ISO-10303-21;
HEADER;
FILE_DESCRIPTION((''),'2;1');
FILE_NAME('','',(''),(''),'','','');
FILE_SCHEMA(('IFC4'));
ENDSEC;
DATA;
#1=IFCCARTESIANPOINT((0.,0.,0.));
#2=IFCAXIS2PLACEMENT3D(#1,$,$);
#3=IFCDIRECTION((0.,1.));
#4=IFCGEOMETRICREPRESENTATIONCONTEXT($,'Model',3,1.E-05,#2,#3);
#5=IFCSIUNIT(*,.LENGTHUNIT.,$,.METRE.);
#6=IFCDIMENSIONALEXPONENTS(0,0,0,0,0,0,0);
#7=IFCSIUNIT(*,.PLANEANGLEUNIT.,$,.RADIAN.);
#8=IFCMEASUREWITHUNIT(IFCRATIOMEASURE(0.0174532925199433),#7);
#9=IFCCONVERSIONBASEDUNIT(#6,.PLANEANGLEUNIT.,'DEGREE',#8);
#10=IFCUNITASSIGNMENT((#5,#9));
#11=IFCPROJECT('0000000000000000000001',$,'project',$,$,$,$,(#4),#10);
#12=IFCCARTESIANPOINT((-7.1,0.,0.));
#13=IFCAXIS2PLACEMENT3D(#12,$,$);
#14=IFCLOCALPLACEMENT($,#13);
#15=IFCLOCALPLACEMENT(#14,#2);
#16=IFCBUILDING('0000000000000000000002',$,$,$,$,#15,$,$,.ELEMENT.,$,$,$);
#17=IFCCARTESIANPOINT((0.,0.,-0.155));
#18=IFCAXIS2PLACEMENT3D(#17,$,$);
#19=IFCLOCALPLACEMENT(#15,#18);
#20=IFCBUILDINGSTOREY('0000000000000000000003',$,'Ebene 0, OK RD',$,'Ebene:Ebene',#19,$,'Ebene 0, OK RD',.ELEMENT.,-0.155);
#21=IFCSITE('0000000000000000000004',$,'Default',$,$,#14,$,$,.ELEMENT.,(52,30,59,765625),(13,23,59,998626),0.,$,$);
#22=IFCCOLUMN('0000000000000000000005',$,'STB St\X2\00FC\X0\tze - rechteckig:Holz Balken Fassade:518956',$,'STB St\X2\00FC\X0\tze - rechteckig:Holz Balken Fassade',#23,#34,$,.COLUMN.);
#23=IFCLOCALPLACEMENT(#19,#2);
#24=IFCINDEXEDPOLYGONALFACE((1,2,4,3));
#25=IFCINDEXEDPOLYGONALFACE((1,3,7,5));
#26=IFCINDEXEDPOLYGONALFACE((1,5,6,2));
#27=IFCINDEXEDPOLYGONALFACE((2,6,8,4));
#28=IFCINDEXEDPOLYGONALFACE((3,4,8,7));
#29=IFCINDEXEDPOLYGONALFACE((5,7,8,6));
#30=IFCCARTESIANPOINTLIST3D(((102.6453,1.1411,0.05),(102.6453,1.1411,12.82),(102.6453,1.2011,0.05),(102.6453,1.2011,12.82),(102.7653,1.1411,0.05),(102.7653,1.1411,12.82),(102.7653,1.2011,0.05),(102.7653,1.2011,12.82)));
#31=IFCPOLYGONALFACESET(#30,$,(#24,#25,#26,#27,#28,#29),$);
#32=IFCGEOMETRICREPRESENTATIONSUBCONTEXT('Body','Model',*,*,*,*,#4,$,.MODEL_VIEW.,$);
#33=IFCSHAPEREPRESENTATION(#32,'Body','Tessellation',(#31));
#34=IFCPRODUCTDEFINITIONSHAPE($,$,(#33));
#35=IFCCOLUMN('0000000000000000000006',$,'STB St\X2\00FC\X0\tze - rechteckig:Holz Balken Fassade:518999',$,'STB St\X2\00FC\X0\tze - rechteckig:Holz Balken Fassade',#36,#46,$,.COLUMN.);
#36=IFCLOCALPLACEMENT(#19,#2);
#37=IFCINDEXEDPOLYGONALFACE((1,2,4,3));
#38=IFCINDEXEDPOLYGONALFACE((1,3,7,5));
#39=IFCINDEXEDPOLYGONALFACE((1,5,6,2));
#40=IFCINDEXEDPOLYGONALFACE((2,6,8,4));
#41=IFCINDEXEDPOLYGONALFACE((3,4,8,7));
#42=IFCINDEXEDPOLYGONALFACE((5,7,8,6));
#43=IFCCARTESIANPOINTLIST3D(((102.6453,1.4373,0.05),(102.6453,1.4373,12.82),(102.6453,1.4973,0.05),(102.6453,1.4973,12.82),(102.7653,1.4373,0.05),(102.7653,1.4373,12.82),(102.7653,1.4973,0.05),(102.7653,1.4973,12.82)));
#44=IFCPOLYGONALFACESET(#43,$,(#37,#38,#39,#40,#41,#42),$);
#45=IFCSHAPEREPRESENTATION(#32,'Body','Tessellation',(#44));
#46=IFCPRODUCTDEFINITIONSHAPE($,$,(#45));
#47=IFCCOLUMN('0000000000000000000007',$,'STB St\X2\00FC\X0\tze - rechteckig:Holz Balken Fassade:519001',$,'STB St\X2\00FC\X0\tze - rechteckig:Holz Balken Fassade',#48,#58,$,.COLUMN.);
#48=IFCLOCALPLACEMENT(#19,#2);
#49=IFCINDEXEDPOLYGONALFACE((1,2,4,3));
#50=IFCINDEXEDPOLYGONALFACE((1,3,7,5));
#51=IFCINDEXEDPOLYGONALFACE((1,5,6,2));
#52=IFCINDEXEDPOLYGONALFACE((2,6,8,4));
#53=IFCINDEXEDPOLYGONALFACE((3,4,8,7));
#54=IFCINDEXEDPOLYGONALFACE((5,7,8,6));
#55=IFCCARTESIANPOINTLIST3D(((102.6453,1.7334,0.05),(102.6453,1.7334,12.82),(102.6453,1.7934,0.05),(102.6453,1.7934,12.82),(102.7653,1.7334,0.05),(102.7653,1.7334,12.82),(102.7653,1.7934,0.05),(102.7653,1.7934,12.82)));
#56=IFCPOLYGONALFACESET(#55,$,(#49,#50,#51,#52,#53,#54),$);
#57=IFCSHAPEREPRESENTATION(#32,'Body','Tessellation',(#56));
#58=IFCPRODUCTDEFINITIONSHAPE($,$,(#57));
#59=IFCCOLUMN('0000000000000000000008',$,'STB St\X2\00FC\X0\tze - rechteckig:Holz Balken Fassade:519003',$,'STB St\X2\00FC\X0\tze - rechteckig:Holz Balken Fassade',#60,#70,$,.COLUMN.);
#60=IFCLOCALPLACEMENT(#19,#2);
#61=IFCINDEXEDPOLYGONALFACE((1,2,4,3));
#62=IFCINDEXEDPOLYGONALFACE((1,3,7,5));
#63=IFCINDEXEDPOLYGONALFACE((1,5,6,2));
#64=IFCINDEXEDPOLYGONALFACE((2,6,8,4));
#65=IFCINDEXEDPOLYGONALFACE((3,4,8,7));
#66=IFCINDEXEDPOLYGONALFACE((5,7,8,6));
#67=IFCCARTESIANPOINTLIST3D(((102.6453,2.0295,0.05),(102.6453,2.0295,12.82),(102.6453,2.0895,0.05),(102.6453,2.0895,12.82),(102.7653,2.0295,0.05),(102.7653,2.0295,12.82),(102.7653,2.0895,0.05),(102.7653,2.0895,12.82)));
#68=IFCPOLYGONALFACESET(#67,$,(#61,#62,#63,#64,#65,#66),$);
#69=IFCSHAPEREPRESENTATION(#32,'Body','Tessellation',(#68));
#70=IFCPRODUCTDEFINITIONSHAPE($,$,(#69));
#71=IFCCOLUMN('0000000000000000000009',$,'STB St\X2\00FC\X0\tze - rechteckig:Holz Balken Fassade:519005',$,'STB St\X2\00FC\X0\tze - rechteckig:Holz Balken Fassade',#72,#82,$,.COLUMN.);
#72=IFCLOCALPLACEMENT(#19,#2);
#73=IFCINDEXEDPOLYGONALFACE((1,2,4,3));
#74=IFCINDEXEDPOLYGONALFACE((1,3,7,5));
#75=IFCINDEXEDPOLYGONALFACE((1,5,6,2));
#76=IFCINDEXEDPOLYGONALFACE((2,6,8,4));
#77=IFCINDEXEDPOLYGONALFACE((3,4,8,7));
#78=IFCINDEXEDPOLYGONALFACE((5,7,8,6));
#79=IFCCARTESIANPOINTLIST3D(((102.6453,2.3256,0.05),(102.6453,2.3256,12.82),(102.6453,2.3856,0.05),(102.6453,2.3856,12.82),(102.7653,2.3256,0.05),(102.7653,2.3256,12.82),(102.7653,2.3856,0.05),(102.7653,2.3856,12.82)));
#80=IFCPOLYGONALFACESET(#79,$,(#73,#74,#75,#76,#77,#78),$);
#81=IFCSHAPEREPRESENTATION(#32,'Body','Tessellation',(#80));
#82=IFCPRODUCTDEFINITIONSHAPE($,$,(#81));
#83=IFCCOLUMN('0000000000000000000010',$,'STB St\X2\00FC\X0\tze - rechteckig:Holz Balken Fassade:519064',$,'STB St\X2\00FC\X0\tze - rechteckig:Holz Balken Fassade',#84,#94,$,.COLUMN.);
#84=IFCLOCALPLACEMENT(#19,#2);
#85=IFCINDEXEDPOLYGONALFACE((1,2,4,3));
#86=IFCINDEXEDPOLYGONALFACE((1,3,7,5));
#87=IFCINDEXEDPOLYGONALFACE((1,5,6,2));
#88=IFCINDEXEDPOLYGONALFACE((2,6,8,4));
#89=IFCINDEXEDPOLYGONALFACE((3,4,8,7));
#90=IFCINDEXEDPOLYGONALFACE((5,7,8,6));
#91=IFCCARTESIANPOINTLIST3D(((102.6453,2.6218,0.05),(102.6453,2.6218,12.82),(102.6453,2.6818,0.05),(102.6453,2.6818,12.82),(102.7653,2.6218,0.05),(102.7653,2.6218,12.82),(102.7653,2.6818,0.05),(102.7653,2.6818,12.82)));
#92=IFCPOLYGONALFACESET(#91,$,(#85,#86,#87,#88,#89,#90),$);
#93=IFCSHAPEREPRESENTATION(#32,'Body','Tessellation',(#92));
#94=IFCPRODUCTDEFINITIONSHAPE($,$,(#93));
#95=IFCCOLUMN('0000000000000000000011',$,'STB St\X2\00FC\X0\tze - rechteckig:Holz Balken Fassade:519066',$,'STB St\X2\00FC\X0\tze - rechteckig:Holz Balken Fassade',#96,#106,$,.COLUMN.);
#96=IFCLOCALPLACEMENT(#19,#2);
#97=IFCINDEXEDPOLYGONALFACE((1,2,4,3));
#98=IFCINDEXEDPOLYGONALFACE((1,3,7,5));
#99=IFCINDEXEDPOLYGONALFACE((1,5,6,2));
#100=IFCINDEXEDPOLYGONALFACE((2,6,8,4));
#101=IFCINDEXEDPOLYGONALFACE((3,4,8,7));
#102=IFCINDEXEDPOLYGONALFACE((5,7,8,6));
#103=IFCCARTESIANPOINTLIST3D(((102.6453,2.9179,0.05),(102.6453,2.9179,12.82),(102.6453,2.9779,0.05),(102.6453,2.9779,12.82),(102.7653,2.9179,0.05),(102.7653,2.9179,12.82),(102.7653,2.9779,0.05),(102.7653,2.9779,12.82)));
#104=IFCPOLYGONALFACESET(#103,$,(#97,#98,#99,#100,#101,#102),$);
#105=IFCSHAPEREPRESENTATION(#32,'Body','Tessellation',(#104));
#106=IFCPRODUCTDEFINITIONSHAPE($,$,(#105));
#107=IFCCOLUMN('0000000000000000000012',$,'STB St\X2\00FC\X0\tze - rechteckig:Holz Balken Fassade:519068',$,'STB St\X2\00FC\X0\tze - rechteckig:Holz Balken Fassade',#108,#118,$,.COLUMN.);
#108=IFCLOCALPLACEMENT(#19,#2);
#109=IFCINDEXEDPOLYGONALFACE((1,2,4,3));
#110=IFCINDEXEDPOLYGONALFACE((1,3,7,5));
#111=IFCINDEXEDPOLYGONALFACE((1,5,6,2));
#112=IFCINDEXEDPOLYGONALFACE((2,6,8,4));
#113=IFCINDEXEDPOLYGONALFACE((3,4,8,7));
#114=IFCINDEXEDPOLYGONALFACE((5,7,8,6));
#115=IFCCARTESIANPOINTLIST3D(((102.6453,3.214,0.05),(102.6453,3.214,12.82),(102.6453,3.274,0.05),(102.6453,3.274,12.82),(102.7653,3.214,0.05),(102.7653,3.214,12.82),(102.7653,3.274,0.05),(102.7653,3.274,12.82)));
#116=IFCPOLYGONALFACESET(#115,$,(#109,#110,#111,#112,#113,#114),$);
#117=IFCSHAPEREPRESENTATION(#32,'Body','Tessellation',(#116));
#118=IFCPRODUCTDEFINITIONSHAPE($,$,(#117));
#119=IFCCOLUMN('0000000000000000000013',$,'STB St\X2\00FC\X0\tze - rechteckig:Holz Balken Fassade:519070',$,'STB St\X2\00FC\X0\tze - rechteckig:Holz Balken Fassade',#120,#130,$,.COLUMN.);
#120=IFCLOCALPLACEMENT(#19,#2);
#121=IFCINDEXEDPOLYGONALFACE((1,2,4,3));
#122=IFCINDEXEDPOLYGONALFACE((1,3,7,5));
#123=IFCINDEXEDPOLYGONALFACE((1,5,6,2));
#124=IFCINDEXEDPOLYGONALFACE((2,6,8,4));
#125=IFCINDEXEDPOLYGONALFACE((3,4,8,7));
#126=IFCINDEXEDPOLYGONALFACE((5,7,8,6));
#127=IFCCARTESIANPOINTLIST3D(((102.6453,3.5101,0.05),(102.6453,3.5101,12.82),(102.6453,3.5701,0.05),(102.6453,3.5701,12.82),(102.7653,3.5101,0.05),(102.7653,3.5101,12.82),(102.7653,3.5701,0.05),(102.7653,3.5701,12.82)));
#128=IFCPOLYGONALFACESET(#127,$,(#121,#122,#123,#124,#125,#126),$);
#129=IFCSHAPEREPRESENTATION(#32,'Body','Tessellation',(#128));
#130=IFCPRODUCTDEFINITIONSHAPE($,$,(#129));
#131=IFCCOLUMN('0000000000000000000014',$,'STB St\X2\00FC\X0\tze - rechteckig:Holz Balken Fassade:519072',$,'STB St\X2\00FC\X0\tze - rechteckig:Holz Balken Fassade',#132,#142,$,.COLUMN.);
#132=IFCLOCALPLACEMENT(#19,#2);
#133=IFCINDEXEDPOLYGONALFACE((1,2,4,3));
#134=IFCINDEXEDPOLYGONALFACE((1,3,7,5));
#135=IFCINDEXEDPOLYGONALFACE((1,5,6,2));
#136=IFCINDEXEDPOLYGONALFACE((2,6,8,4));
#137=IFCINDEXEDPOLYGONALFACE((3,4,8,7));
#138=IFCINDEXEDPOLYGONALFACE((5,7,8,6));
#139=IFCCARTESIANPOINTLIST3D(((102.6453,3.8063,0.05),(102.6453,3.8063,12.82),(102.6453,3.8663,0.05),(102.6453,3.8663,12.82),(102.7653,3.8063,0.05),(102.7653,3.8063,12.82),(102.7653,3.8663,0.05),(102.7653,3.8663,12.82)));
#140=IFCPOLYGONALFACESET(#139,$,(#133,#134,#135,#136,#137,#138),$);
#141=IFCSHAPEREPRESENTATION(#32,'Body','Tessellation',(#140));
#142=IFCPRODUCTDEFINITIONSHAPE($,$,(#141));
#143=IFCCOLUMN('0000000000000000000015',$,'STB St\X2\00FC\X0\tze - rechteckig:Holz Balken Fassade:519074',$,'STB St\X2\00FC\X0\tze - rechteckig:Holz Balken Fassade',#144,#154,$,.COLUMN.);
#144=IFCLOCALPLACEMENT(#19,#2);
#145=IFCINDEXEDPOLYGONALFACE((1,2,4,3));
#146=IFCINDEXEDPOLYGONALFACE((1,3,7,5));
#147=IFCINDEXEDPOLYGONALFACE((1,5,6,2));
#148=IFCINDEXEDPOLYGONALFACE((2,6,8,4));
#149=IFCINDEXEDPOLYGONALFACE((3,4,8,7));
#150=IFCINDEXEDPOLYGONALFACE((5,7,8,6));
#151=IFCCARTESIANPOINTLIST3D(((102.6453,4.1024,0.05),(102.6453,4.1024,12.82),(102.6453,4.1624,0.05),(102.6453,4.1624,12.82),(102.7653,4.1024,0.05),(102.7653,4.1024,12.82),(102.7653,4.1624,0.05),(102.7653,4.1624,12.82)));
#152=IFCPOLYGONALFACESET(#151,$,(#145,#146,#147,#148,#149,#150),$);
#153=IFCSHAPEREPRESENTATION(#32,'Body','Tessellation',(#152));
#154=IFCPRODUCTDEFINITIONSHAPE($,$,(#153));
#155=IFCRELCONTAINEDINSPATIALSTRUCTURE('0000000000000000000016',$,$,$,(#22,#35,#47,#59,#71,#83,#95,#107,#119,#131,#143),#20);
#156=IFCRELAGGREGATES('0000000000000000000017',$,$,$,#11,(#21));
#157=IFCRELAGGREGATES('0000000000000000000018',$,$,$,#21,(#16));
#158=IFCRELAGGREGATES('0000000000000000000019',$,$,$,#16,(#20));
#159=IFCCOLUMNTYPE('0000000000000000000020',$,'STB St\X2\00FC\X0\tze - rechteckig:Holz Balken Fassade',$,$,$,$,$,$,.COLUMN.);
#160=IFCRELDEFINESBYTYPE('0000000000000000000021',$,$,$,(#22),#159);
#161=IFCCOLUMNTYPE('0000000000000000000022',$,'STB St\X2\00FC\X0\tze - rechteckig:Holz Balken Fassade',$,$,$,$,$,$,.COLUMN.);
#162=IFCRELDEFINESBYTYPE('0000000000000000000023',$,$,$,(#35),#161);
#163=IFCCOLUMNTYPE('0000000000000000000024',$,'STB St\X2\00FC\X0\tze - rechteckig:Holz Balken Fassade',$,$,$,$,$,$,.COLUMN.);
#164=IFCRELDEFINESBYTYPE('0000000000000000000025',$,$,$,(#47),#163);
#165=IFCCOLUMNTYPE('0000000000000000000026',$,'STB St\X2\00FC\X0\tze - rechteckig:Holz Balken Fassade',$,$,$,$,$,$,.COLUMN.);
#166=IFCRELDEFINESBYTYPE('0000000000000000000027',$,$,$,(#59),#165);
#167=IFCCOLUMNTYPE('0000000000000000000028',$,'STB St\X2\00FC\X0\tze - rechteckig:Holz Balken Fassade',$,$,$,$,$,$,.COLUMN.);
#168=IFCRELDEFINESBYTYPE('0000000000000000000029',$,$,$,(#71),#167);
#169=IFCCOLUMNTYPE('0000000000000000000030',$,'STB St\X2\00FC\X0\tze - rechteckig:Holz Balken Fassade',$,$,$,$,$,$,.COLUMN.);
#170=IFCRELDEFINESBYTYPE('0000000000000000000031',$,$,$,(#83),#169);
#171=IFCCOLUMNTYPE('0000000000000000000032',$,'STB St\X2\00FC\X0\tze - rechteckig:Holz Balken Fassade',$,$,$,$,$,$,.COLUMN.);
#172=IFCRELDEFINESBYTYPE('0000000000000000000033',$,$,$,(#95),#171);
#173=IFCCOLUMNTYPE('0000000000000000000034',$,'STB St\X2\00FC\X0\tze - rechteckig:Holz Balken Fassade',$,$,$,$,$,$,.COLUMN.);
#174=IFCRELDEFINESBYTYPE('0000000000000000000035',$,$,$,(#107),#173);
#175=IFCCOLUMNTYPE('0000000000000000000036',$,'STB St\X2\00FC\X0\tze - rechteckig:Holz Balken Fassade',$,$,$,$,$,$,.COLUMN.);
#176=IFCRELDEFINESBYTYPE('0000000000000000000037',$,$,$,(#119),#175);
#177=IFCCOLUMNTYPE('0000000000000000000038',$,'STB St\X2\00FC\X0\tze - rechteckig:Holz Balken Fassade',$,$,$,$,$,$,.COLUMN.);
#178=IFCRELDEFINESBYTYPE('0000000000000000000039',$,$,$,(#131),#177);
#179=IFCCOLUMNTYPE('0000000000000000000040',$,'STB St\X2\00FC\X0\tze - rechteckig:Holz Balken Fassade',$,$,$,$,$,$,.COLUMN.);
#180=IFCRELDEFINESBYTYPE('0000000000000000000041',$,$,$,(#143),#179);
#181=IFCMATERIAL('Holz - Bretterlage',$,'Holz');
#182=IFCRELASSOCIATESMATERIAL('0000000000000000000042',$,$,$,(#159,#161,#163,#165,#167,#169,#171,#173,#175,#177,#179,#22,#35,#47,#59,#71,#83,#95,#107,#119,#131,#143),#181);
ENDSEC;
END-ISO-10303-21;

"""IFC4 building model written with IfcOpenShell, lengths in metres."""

from ifc_helpers import new_model, entity, si_unit, converted_unit, direction, frame, frame_2d, origin, place, context, subcontext, project, spatial, rectangle, extrude, source, transform, mapped, material, material_profile, profile_set, profile_usage, type_object, type_shapes, element, save


model = new_model("IFC4")

# Units and contexts
model_context = context("Model", 3, precision=1e-05, world=origin(), true_north=direction((0.0, 1.0)))
body_context = subcontext(model_context, "Body", "Model", "MODEL_VIEW")
ifc_project = project(units=[si_unit("LENGTHUNIT", "METRE"), converted_unit("PLANEANGLEUNIT", "DEGREE", entity("IfcRatioMeasure", 0.0174532925199433), si_unit("PLANEANGLEUNIT", "RADIAN"), dimensions=[0, 0, 0, 0, 0, 0, 0])], contexts=[model_context])

# Site, building, storey
site_placement = place(None, frame((-7.1, 0.0, 0.0)))
site = spatial("IfcSite", under=ifc_project, at=site_placement, Name="Default", CompositionType="ELEMENT", RefLatitude=(52, 30, 59, 765625), RefLongitude=(13, 23, 59, 998626), RefElevation=0.0)
building_placement = place(site_placement, origin())
building = spatial("IfcBuilding", under=site, at=building_placement, CompositionType="ELEMENT")
storey_placement = place(building_placement, frame((0.0, 0.0, -0.155)))
storey = spatial("IfcBuildingStorey", under=building, at=storey_placement, Name="Ebene 0, OK RD", ObjectType="Ebene:Ebene", LongName="Ebene 0, OK RD", CompositionType="ELEMENT", Elevation=-0.155)

# Columns
ifc_material = material(Name="Holz - Bretterlage", Category="Holz")
ifc_material_profile = material_profile(ifc_material, rectangle(XDim=0.12, YDim=0.06, at=frame_2d((0.0, 0.0), x_axis=(1.0, 0.0))), Name="Holz Balken Fassade")
ifc_profile_set = profile_set([ifc_material_profile], Name="Holz Balken Fassade")
ifc_profile_usage_1 = profile_usage(ifc_profile_set)
column_type_1 = type_object("IfcColumnType", Name="STB Stütze - rechteckig:Holz Balken Fassade", PredefinedType="COLUMN", material=ifc_profile_set)
shared_shape_1 = source(origin(), body_context, "Body", "SweptSolid", [
    extrude(rectangle(XDim=0.06, YDim=0.12, at=frame_2d((0.0, 0.0), x_axis=(1.0, 0.0))), frame((102.7053, 1.1711, -0.105), z_axis=(0.0, 0.0, 1.0), x_axis=(0.0, -1.0, 0.0)), (0.0, 0.0, 1.0), 12.77),
])
type_shapes(column_type_1, [shared_shape_1])
column_1_placement = place(storey_placement, frame((0.0, 0.0, 0.155)))
element("IfcColumn", 1, at=column_1_placement, inside=storey, type_object=column_type_1, material=ifc_profile_usage_1, Name="STB Stütze - rechteckig:Holz Balken Fassade:518956", ObjectType="STB Stütze - rechteckig:Holz Balken Fassade", PredefinedType="COLUMN", context=body_context, shape_type="MappedRepresentation", body=[
    mapped(shared_shape_1, transform((0.0, 0.0, 0.0), scale=1.0)),
])
ifc_profile_usage_2 = profile_usage(ifc_profile_set)
column_type_2 = type_object("IfcColumnType", Name="STB Stütze - rechteckig:Holz Balken Fassade", PredefinedType="COLUMN", material=ifc_profile_set)
shared_shape_2 = source(origin(), body_context, "Body", "SweptSolid", [
    extrude(rectangle(XDim=0.06, YDim=0.12, at=frame_2d((0.0, 0.0), x_axis=(1.0, 0.0))), frame((102.7053, 1.4673, -0.105), z_axis=(0.0, 0.0, 1.0), x_axis=(0.0, -1.0, 0.0)), (0.0, 0.0, 1.0), 12.77),
])
type_shapes(column_type_2, [shared_shape_2])
column_2_placement = place(storey_placement, frame((0.0, 0.0, 0.155)))
element("IfcColumn", 2, at=column_2_placement, inside=storey, type_object=column_type_2, material=ifc_profile_usage_2, Name="STB Stütze - rechteckig:Holz Balken Fassade:518999", ObjectType="STB Stütze - rechteckig:Holz Balken Fassade", PredefinedType="COLUMN", context=body_context, shape_type="MappedRepresentation", body=[
    mapped(shared_shape_2, transform((0.0, 0.0, 0.0), scale=1.0)),
])
ifc_profile_usage_3 = profile_usage(ifc_profile_set)
column_type_3 = type_object("IfcColumnType", Name="STB Stütze - rechteckig:Holz Balken Fassade", PredefinedType="COLUMN", material=ifc_profile_set)
shared_shape_3 = source(origin(), body_context, "Body", "SweptSolid", [
    extrude(rectangle(XDim=0.06, YDim=0.12, at=frame_2d((0.0, 0.0), x_axis=(1.0, 0.0))), frame((102.7053, 1.7634, -0.105), z_axis=(0.0, 0.0, 1.0), x_axis=(0.0, -1.0, 0.0)), (0.0, 0.0, 1.0), 12.77),
])
type_shapes(column_type_3, [shared_shape_3])
column_3_placement = place(storey_placement, frame((0.0, 0.0, 0.155)))
element("IfcColumn", 3, at=column_3_placement, inside=storey, type_object=column_type_3, material=ifc_profile_usage_3, Name="STB Stütze - rechteckig:Holz Balken Fassade:519001", ObjectType="STB Stütze - rechteckig:Holz Balken Fassade", PredefinedType="COLUMN", context=body_context, shape_type="MappedRepresentation", body=[
    mapped(shared_shape_3, transform((0.0, 0.0, 0.0), scale=1.0)),
])
ifc_profile_usage_4 = profile_usage(ifc_profile_set)
column_type_4 = type_object("IfcColumnType", Name="STB Stütze - rechteckig:Holz Balken Fassade", PredefinedType="COLUMN", material=ifc_profile_set)
shared_shape_4 = source(origin(), body_context, "Body", "SweptSolid", [
    extrude(rectangle(XDim=0.06, YDim=0.12, at=frame_2d((0.0, 0.0), x_axis=(1.0, 0.0))), frame((102.7053, 2.0595, -0.105), z_axis=(0.0, 0.0, 1.0), x_axis=(0.0, -1.0, 0.0)), (0.0, 0.0, 1.0), 12.77),
])
type_shapes(column_type_4, [shared_shape_4])
column_4_placement = place(storey_placement, frame((0.0, 0.0, 0.155)))
element("IfcColumn", 4, at=column_4_placement, inside=storey, type_object=column_type_4, material=ifc_profile_usage_4, Name="STB Stütze - rechteckig:Holz Balken Fassade:519003", ObjectType="STB Stütze - rechteckig:Holz Balken Fassade", PredefinedType="COLUMN", context=body_context, shape_type="MappedRepresentation", body=[
    mapped(shared_shape_4, transform((0.0, 0.0, 0.0), scale=1.0)),
])
ifc_profile_usage_5 = profile_usage(ifc_profile_set)
column_type_5 = type_object("IfcColumnType", Name="STB Stütze - rechteckig:Holz Balken Fassade", PredefinedType="COLUMN", material=ifc_profile_set)
shared_shape_5 = source(origin(), body_context, "Body", "SweptSolid", [
    extrude(rectangle(XDim=0.06, YDim=0.12, at=frame_2d((0.0, 0.0), x_axis=(1.0, 0.0))), frame((102.7053, 2.3556, -0.105), z_axis=(0.0, 0.0, 1.0), x_axis=(0.0, -1.0, 0.0)), (0.0, 0.0, 1.0), 12.77),
])
type_shapes(column_type_5, [shared_shape_5])
column_5_placement = place(storey_placement, frame((0.0, 0.0, 0.155)))
element("IfcColumn", 5, at=column_5_placement, inside=storey, type_object=column_type_5, material=ifc_profile_usage_5, Name="STB Stütze - rechteckig:Holz Balken Fassade:519005", ObjectType="STB Stütze - rechteckig:Holz Balken Fassade", PredefinedType="COLUMN", context=body_context, shape_type="MappedRepresentation", body=[
    mapped(shared_shape_5, transform((0.0, 0.0, 0.0), scale=1.0)),
])
ifc_profile_usage_6 = profile_usage(ifc_profile_set)
column_type_6 = type_object("IfcColumnType", Name="STB Stütze - rechteckig:Holz Balken Fassade", PredefinedType="COLUMN", material=ifc_profile_set)
shared_shape_6 = source(origin(), body_context, "Body", "SweptSolid", [
    extrude(rectangle(XDim=0.06, YDim=0.12, at=frame_2d((0.0, 0.0), x_axis=(1.0, 0.0))), frame((102.7053, 2.6518, -0.105), z_axis=(0.0, 0.0, 1.0), x_axis=(0.0, -1.0, 0.0)), (0.0, 0.0, 1.0), 12.77),
])
type_shapes(column_type_6, [shared_shape_6])
column_6_placement = place(storey_placement, frame((0.0, 0.0, 0.155)))
element("IfcColumn", 6, at=column_6_placement, inside=storey, type_object=column_type_6, material=ifc_profile_usage_6, Name="STB Stütze - rechteckig:Holz Balken Fassade:519064", ObjectType="STB Stütze - rechteckig:Holz Balken Fassade", PredefinedType="COLUMN", context=body_context, shape_type="MappedRepresentation", body=[
    mapped(shared_shape_6, transform((0.0, 0.0, 0.0), scale=1.0)),
])
ifc_profile_usage_7 = profile_usage(ifc_profile_set)
column_type_7 = type_object("IfcColumnType", Name="STB Stütze - rechteckig:Holz Balken Fassade", PredefinedType="COLUMN", material=ifc_profile_set)
shared_shape_7 = source(origin(), body_context, "Body", "SweptSolid", [
    extrude(rectangle(XDim=0.06, YDim=0.12, at=frame_2d((0.0, 0.0), x_axis=(1.0, 0.0))), frame((102.7053, 2.9479, -0.105), z_axis=(0.0, 0.0, 1.0), x_axis=(0.0, -1.0, 0.0)), (0.0, 0.0, 1.0), 12.77),
])
type_shapes(column_type_7, [shared_shape_7])
column_7_placement = place(storey_placement, frame((0.0, 0.0, 0.155)))
element("IfcColumn", 7, at=column_7_placement, inside=storey, type_object=column_type_7, material=ifc_profile_usage_7, Name="STB Stütze - rechteckig:Holz Balken Fassade:519066", ObjectType="STB Stütze - rechteckig:Holz Balken Fassade", PredefinedType="COLUMN", context=body_context, shape_type="MappedRepresentation", body=[
    mapped(shared_shape_7, transform((0.0, 0.0, 0.0), scale=1.0)),
])
ifc_profile_usage_8 = profile_usage(ifc_profile_set)
column_type_8 = type_object("IfcColumnType", Name="STB Stütze - rechteckig:Holz Balken Fassade", PredefinedType="COLUMN", material=ifc_profile_set)
shared_shape_8 = source(origin(), body_context, "Body", "SweptSolid", [
    extrude(rectangle(XDim=0.06, YDim=0.12, at=frame_2d((0.0, 0.0), x_axis=(1.0, 0.0))), frame((102.7053, 3.244, -0.105), z_axis=(0.0, 0.0, 1.0), x_axis=(0.0, -1.0, 0.0)), (0.0, 0.0, 1.0), 12.77),
])
type_shapes(column_type_8, [shared_shape_8])
column_8_placement = place(storey_placement, frame((0.0, 0.0, 0.155)))
element("IfcColumn", 8, at=column_8_placement, inside=storey, type_object=column_type_8, material=ifc_profile_usage_8, Name="STB Stütze - rechteckig:Holz Balken Fassade:519068", ObjectType="STB Stütze - rechteckig:Holz Balken Fassade", PredefinedType="COLUMN", context=body_context, shape_type="MappedRepresentation", body=[
    mapped(shared_shape_8, transform((0.0, 0.0, 0.0), scale=1.0)),
])
ifc_profile_usage_9 = profile_usage(ifc_profile_set)
column_type_9 = type_object("IfcColumnType", Name="STB Stütze - rechteckig:Holz Balken Fassade", PredefinedType="COLUMN", material=ifc_profile_set)
shared_shape_9 = source(origin(), body_context, "Body", "SweptSolid", [
    extrude(rectangle(XDim=0.06, YDim=0.12, at=frame_2d((0.0, 0.0), x_axis=(1.0, 0.0))), frame((102.7053, 3.5401, -0.105), z_axis=(0.0, 0.0, 1.0), x_axis=(0.0, -1.0, 0.0)), (0.0, 0.0, 1.0), 12.77),
])
type_shapes(column_type_9, [shared_shape_9])
column_9_placement = place(storey_placement, frame((0.0, 0.0, 0.155)))
element("IfcColumn", 9, at=column_9_placement, inside=storey, type_object=column_type_9, material=ifc_profile_usage_9, Name="STB Stütze - rechteckig:Holz Balken Fassade:519070", ObjectType="STB Stütze - rechteckig:Holz Balken Fassade", PredefinedType="COLUMN", context=body_context, shape_type="MappedRepresentation", body=[
    mapped(shared_shape_9, transform((0.0, 0.0, 0.0), scale=1.0)),
])
ifc_profile_usage_10 = profile_usage(ifc_profile_set)
column_type_10 = type_object("IfcColumnType", Name="STB Stütze - rechteckig:Holz Balken Fassade", PredefinedType="COLUMN", material=ifc_profile_set)
shared_shape_10 = source(origin(), body_context, "Body", "SweptSolid", [
    extrude(rectangle(XDim=0.06, YDim=0.12, at=frame_2d((0.0, 0.0), x_axis=(1.0, 0.0))), frame((102.7053, 3.8363, -0.105), z_axis=(0.0, 0.0, 1.0), x_axis=(0.0, -1.0, 0.0)), (0.0, 0.0, 1.0), 12.77),
])
type_shapes(column_type_10, [shared_shape_10])
column_10_placement = place(storey_placement, frame((0.0, 0.0, 0.155)))
element("IfcColumn", 10, at=column_10_placement, inside=storey, type_object=column_type_10, material=ifc_profile_usage_10, Name="STB Stütze - rechteckig:Holz Balken Fassade:519072", ObjectType="STB Stütze - rechteckig:Holz Balken Fassade", PredefinedType="COLUMN", context=body_context, shape_type="MappedRepresentation", body=[
    mapped(shared_shape_10, transform((0.0, 0.0, 0.0), scale=1.0)),
])
ifc_profile_usage_11 = profile_usage(ifc_profile_set)
column_type_11 = type_object("IfcColumnType", Name="STB Stütze - rechteckig:Holz Balken Fassade", PredefinedType="COLUMN", material=ifc_profile_set)
shared_shape_11 = source(origin(), body_context, "Body", "SweptSolid", [
    extrude(rectangle(XDim=0.06, YDim=0.12, at=frame_2d((0.0, 0.0), x_axis=(1.0, 0.0))), frame((102.7053, 4.1324, -0.105), z_axis=(0.0, 0.0, 1.0), x_axis=(0.0, -1.0, 0.0)), (0.0, 0.0, 1.0), 12.77),
])
type_shapes(column_type_11, [shared_shape_11])
column_11_placement = place(storey_placement, frame((0.0, 0.0, 0.155)))
element("IfcColumn", 11, at=column_11_placement, inside=storey, type_object=column_type_11, material=ifc_profile_usage_11, Name="STB Stütze - rechteckig:Holz Balken Fassade:519074", ObjectType="STB Stütze - rechteckig:Holz Balken Fassade", PredefinedType="COLUMN", context=body_context, shape_type="MappedRepresentation", body=[
    mapped(shared_shape_11, transform((0.0, 0.0, 0.0), scale=1.0)),
])

save(model, "model.ifc")
